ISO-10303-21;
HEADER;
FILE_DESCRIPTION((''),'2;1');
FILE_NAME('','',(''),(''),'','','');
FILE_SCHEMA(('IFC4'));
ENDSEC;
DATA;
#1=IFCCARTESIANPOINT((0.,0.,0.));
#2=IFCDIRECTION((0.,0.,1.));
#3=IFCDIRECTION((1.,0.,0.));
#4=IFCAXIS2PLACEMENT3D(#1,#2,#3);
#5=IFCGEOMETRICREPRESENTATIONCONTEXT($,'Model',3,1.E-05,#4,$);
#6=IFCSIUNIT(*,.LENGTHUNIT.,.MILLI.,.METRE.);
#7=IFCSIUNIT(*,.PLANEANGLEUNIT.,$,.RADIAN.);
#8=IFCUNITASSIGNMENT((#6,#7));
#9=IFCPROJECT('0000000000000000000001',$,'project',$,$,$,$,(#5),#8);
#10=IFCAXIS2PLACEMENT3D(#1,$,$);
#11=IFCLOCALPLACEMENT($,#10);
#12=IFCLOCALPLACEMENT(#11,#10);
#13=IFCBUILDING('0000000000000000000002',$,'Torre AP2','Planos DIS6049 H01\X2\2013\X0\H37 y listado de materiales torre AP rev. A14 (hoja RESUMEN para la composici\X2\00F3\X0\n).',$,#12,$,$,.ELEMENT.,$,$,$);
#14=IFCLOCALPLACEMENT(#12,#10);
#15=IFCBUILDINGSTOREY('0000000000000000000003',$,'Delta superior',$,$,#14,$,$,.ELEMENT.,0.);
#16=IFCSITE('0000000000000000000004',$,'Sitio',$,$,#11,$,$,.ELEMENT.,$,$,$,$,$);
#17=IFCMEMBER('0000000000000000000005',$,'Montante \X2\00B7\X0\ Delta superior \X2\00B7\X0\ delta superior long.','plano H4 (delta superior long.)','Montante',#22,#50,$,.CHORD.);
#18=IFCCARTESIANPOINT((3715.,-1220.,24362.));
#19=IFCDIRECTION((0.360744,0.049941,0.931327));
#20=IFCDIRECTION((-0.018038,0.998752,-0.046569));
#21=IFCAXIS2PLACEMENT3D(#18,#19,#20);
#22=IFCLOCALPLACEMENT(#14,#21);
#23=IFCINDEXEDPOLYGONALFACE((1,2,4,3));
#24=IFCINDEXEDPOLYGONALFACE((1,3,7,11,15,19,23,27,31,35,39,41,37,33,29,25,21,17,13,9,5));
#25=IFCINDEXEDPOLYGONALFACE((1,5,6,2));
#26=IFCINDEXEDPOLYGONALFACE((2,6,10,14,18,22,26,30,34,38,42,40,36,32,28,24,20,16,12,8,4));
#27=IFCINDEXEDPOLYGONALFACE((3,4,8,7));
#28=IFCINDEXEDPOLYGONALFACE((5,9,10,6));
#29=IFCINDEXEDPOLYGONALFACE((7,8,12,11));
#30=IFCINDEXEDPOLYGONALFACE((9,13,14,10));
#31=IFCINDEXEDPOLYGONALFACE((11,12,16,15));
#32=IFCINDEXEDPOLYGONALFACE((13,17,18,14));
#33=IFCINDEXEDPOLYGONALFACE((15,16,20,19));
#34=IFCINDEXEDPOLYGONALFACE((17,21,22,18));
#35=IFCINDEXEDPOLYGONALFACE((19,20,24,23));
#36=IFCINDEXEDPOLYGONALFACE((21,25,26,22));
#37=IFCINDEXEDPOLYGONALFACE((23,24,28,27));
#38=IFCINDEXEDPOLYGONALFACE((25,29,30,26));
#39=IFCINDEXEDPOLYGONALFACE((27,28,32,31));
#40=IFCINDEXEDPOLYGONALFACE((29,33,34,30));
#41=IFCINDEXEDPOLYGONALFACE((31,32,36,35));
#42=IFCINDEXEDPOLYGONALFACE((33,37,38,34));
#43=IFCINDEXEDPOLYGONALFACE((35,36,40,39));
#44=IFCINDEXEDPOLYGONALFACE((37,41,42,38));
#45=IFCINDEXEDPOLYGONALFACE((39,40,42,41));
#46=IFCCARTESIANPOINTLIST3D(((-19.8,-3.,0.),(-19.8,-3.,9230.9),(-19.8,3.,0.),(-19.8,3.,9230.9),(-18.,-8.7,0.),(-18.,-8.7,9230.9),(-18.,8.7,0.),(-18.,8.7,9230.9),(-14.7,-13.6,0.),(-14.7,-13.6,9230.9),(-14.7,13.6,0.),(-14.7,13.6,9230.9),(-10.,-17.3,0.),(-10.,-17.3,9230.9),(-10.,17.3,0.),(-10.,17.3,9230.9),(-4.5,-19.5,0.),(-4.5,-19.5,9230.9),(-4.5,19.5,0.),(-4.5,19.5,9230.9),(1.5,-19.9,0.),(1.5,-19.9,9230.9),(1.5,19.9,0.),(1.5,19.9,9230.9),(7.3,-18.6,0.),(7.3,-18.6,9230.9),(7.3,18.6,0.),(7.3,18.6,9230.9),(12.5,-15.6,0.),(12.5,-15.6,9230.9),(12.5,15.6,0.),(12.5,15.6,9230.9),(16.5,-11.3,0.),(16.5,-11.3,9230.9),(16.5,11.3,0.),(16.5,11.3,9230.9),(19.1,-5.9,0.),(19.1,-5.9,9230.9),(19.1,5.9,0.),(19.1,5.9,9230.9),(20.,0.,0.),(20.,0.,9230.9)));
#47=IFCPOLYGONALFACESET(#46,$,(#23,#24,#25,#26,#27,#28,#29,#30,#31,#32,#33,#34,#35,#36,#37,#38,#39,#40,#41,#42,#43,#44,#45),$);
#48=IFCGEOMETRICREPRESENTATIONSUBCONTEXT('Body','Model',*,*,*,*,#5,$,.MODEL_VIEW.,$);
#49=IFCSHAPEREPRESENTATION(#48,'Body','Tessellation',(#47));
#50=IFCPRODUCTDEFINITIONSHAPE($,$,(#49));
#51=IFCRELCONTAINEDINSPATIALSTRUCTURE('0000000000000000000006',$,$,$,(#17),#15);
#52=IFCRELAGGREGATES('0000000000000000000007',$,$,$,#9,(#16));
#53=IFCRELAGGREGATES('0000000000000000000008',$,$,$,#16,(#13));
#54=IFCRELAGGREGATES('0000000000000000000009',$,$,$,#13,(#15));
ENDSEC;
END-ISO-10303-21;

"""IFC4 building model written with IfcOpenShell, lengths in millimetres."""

from ifc_helpers import new_model, si_unit, frame, origin, origin_with_axes, place, context, subcontext, project, spatial, circle, extrude, element, save


model = new_model("IFC4")

# Units and contexts
model_context = context("Model", 3, precision=1e-05, world=origin_with_axes())
body_context = subcontext(model_context, "Body", "Model", "MODEL_VIEW")
ifc_project = project(units=[si_unit("LENGTHUNIT", "METRE", prefix="MILLI"), si_unit("PLANEANGLEUNIT", "RADIAN")], contexts=[model_context])

# Site, building, storey
site_placement = place(None, origin())
site = spatial("IfcSite", under=ifc_project, at=site_placement, Name="Sitio", CompositionType="ELEMENT")
building_placement = place(site_placement, origin())
building = spatial("IfcBuilding", under=site, at=building_placement, Name="Torre AP2", Description="Planos DIS6049 H01–H37 y listado de materiales torre AP rev. A14 (hoja RESUMEN para la composición).", CompositionType="ELEMENT")
storey_placement = place(building_placement, origin())
storey = spatial("IfcBuildingStorey", under=building, at=storey_placement, Name="Delta superior", CompositionType="ELEMENT", Elevation=0.0)

# Member
for number, where, z_axis, x_axis, name in (
    (1, (3715.0, -1220.0, 24362.0), (0.360744, 0.049941, 0.931327), (-0.018038, 0.998752, -0.046569), "Montante · Delta superior · delta superior long."),
):
    element("IfcMember", number, at=place(storey_placement, frame(where, z_axis=z_axis, x_axis=x_axis)), inside=storey, Name=name, Description="plano H4 (delta superior long.)", ObjectType="Montante", PredefinedType="CHORD", context=body_context, shape_type="SweptSolid", body=[
        extrude(circle(Radius=20.0), None, (0.0, 0.0, 1.0), 9230.9),
    ])

save(model, "model.ifc")
